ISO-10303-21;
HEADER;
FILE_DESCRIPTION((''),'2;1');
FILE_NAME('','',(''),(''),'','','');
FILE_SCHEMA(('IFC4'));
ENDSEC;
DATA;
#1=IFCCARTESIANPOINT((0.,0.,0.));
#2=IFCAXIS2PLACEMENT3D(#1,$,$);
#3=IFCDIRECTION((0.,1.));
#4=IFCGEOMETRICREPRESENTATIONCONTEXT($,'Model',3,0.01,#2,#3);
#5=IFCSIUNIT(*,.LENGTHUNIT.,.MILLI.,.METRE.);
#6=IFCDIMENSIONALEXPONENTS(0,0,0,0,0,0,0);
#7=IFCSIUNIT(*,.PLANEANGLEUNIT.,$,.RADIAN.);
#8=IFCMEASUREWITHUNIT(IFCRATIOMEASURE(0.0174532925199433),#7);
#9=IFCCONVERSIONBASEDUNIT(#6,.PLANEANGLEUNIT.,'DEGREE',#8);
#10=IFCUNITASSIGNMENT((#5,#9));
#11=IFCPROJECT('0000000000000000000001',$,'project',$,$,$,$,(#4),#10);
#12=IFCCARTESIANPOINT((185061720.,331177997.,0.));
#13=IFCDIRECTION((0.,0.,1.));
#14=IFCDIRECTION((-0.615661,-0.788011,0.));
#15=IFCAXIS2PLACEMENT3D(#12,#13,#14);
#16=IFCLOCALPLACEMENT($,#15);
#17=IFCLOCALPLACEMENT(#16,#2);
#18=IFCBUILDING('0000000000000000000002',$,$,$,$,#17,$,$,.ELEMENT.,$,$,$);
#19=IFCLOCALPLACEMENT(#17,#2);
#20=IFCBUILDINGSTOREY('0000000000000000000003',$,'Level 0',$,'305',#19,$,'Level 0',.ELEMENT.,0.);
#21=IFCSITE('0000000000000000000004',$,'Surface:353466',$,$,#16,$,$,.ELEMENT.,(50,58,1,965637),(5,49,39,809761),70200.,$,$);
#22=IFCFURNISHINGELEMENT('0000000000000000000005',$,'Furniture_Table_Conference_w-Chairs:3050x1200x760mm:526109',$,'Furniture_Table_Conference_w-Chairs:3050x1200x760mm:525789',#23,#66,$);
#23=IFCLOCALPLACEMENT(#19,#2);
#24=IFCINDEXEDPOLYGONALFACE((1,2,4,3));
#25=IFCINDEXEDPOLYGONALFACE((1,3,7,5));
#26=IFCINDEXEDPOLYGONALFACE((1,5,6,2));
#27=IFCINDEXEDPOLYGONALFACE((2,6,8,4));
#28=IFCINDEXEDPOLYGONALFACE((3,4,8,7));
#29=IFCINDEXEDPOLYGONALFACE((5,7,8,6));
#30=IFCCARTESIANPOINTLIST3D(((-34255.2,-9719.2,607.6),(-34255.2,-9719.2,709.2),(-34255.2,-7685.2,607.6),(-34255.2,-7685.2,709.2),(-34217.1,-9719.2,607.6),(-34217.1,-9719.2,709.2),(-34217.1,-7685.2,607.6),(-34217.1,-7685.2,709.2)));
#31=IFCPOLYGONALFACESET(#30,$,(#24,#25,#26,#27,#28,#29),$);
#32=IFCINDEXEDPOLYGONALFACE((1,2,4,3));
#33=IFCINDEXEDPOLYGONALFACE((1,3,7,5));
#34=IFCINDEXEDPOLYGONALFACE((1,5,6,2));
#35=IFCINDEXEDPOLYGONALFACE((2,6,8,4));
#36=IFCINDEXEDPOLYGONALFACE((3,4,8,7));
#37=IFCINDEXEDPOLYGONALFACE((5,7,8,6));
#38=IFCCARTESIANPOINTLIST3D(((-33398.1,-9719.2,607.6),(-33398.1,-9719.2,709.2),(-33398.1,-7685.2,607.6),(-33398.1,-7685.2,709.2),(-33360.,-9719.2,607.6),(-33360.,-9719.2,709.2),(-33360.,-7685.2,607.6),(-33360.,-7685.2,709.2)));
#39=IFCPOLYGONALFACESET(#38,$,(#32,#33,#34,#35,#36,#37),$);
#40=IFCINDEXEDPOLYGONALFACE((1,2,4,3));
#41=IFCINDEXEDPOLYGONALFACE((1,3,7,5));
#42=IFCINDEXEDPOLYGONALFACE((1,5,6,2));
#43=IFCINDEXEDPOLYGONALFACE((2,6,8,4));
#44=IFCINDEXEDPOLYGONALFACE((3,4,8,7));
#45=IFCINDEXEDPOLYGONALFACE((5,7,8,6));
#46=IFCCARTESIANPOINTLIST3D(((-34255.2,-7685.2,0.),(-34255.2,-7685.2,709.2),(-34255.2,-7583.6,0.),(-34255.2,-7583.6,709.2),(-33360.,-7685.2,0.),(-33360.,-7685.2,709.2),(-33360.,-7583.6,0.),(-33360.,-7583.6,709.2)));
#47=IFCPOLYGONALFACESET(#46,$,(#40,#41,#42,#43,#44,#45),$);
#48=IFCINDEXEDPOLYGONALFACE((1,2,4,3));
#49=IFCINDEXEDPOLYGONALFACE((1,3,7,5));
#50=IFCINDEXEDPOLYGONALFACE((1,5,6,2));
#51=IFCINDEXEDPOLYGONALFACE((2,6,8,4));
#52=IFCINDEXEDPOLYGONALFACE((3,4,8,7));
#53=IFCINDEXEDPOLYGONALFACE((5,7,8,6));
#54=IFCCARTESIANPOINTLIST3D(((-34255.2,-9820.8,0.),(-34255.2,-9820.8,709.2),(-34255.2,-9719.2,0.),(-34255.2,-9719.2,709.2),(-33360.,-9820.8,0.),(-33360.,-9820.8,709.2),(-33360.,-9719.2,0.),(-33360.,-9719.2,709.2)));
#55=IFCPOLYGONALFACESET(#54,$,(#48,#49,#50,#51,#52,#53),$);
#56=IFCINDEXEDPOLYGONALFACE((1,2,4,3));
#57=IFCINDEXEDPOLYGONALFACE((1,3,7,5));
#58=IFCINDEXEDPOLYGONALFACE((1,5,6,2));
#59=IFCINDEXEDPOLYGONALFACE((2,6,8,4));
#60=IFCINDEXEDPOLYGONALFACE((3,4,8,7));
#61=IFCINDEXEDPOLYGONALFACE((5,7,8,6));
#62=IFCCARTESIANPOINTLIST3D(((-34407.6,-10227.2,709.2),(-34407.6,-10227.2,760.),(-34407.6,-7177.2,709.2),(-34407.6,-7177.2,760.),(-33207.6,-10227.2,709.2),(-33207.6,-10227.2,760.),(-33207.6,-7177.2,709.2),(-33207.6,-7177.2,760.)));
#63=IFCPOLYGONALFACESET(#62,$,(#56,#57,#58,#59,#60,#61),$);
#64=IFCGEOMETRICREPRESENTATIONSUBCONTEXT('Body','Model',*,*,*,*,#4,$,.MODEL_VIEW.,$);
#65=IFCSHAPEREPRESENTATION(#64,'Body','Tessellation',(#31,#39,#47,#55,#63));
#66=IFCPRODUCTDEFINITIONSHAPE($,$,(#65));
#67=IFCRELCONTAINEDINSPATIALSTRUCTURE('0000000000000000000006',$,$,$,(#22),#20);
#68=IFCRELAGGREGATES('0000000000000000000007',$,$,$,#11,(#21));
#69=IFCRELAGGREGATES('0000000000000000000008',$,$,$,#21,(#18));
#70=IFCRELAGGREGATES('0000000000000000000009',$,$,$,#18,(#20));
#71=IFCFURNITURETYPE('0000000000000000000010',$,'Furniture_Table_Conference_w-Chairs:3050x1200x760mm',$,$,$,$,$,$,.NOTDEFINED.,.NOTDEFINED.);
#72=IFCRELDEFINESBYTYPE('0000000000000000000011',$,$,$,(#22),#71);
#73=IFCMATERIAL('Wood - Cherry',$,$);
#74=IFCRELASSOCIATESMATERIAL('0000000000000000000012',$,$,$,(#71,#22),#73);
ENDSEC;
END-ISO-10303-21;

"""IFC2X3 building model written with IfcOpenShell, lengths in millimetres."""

from ifc_helpers import new_model, entity, si_unit, converted_unit, direction, frame, frame_2d, origin, origin_2d_with_axis, place, context, subcontext, project, spatial, rectangle, extrude, source, transform, mapped, material, type_object, type_shapes, element, save


model = new_model("IFC2X3")

# Units and contexts
model_context = context("Model", 3, precision=0.01, world=origin(), true_north=direction((0.0, 1.0)))
body_context = subcontext(model_context, "Body", "Model", "MODEL_VIEW")
ifc_project = project(units=[si_unit("LENGTHUNIT", "METRE", prefix="MILLI"), converted_unit("PLANEANGLEUNIT", "DEGREE", entity("IfcRatioMeasure", 0.0174532925199433), si_unit("PLANEANGLEUNIT", "RADIAN"), dimensions=[0, 0, 0, 0, 0, 0, 0])], contexts=[model_context])

# Site, building, storey
site_placement = place(None, frame((185061720.0, 331177997.0, 0.0), z_axis=(0.0, 0.0, 1.0), x_axis=(-0.615661, -0.788011, 0.0)))
site = spatial("IfcSite", under=ifc_project, at=site_placement, Name="Surface:353466", CompositionType="ELEMENT", RefLatitude=(50, 58, 1, 965637), RefLongitude=(5, 49, 39, 809761), RefElevation=70200.0)
building_placement = place(site_placement, origin())
building = spatial("IfcBuilding", under=site, at=building_placement, CompositionType="ELEMENT")
storey_placement = place(building_placement, origin())
storey = spatial("IfcBuildingStorey", under=building, at=storey_placement, Name="Level 0", ObjectType="305", LongName="Level 0", CompositionType="ELEMENT", Elevation=0.0)

# Furnishing element
ifc_material_1 = material(Name="Wood - Cherry")
furniture_type_1 = type_object("IfcFurnitureType", Name="Furniture_Table_Conference_w-Chairs:3050x1200x760mm", material=ifc_material_1)
shared_shape_1 = source(origin(), body_context, "Body", "SweptSolid", [
    extrude(rectangle(XDim=2034.0, YDim=38.1, at=origin_2d_with_axis()), frame((0.0, 428.6, 607.6), z_axis=(0.0, 0.0, 1.0), x_axis=(-1.0, 0.0, 0.0)), (0.0, 0.0, 1.0), 101.6),
    extrude(rectangle(XDim=38.1, YDim=2034.0, at=origin_2d_with_axis()), frame((0.0, -428.6, 607.6), z_axis=(0.0, 0.0, 1.0), x_axis=(0.0, 1.0, 0.0)), (0.0, 0.0, 1.0), 101.6),
    extrude(rectangle(XDim=895.2, YDim=101.6, at=origin_2d_with_axis()), frame((1067.8, 0.0, 0.0), z_axis=(0.0, 0.0, 1.0), x_axis=(0.0, 1.0, 0.0)), (0.0, 0.0, 1.0), 709.2),
    extrude(rectangle(XDim=895.2, YDim=101.6, at=frame_2d((0.0, 0.0), x_axis=(1.0, 0.0))), frame((-1067.8, 0.0, 0.0), z_axis=(0.0, 0.0, 1.0), x_axis=(0.0, 1.0, 0.0)), (0.0, 0.0, 1.0), 709.2),
    extrude(rectangle(XDim=1200.0, YDim=3050.0, at=origin_2d_with_axis()), frame((0.0, 0.0, 709.2), z_axis=(0.0, 0.0, 1.0), x_axis=(0.0, 1.0, 0.0)), (0.0, 0.0, 1.0), 50.8),
])
type_shapes(furniture_type_1, [shared_shape_1])
furnishing_1_placement = place(storey_placement, frame((-33807.6, -8702.2, 0.0), z_axis=(0.0, 0.0, 1.0), x_axis=(0.0, 1.0, 0.0)))
element("IfcFurnishingElement", 1, at=furnishing_1_placement, inside=storey, type_object=furniture_type_1, material=ifc_material_1, Name="Furniture_Table_Conference_w-Chairs:3050x1200x760mm:526109", ObjectType="Furniture_Table_Conference_w-Chairs:3050x1200x760mm:525789", context=body_context, shape_type="MappedRepresentation", body=[
    mapped(shared_shape_1, transform((0.0, 0.0, 0.0), scale=1.0)),
])

save(model, "model.ifc")
